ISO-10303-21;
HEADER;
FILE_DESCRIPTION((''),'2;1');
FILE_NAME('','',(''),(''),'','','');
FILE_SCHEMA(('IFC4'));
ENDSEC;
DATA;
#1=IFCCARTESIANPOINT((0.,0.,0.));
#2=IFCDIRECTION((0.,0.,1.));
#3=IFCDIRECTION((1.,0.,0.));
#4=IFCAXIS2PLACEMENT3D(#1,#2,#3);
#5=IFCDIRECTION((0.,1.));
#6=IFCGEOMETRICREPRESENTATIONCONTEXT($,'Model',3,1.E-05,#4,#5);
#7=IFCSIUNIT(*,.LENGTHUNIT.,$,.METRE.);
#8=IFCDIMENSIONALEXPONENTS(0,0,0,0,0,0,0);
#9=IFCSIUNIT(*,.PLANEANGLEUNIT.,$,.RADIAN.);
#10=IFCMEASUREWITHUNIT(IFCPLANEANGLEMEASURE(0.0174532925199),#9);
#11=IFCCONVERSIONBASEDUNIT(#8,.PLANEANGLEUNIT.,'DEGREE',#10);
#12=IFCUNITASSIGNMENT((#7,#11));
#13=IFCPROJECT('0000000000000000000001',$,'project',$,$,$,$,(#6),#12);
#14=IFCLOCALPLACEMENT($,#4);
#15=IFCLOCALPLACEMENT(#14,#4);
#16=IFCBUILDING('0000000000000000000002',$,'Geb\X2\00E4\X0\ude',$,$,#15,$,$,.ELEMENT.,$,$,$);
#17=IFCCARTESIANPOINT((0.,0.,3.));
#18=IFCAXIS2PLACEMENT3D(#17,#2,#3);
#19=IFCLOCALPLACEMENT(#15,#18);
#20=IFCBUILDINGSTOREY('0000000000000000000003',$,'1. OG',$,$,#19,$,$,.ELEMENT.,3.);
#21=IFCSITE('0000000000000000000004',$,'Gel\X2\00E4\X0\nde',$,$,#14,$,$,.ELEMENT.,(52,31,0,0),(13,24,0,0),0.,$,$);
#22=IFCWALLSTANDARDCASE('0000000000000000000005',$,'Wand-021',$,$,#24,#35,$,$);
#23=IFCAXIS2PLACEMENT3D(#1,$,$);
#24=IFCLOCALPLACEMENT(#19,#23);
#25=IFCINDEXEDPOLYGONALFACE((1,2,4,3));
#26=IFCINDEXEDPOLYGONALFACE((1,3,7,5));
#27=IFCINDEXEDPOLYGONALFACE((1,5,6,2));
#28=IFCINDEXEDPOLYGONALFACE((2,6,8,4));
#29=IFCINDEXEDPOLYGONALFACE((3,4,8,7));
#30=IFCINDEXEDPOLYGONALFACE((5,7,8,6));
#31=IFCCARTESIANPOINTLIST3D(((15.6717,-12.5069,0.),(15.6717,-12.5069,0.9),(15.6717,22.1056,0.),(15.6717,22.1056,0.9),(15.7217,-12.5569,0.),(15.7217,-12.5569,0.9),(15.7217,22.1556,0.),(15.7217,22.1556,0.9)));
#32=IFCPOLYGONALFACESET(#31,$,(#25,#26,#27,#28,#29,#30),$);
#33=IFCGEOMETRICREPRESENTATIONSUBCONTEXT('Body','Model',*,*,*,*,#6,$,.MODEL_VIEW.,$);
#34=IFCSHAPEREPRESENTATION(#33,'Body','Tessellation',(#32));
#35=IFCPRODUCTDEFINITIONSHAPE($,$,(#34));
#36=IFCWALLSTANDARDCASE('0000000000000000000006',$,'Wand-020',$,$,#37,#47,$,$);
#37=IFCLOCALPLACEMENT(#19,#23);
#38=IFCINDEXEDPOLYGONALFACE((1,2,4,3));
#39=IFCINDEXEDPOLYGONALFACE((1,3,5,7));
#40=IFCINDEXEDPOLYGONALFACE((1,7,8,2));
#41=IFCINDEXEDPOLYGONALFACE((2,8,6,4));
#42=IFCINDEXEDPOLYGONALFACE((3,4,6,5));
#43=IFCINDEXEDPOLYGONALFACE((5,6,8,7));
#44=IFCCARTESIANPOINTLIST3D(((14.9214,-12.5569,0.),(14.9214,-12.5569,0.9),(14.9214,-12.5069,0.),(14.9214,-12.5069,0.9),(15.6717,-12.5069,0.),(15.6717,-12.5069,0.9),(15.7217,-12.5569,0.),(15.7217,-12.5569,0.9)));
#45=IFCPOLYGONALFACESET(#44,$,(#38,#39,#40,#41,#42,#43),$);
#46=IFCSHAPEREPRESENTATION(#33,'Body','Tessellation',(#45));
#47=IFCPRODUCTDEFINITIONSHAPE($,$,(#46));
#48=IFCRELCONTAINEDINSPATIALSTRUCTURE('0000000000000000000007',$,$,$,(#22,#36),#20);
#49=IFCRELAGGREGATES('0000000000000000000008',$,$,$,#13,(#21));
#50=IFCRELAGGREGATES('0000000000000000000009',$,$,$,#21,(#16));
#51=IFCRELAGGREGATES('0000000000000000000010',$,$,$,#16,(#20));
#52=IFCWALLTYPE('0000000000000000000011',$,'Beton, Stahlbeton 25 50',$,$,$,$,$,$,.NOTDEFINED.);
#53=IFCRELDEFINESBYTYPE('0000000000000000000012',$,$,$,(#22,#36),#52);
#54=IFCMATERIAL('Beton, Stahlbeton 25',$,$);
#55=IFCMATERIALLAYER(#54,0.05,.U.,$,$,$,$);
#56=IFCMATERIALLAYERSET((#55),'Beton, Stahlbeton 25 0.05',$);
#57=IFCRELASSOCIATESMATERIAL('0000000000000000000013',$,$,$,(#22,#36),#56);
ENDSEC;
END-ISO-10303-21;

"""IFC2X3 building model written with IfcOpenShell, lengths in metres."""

from ifc_helpers import new_model, entity, si_unit, converted_unit, direction, frame, origin_with_axes, place, context, subcontext, project, spatial, polyline, outline, extrude, material, layer, layer_set, layer_usage, type_object, element, save


model = new_model("IFC2X3")

# Units and contexts
model_context = context("Model", 3, precision=1e-05, world=origin_with_axes(), true_north=direction((0.0, 1.0)))
body_context = subcontext(model_context, "Body", "Model", "MODEL_VIEW")
ifc_project = project(units=[si_unit("LENGTHUNIT", "METRE"), converted_unit("PLANEANGLEUNIT", "DEGREE", entity("IfcPlaneAngleMeasure", 0.0174532925199), si_unit("PLANEANGLEUNIT", "RADIAN"), dimensions=[0, 0, 0, 0, 0, 0, 0])], contexts=[model_context])

# Site, building, storey
site_placement = place(None, origin_with_axes())
site = spatial("IfcSite", under=ifc_project, at=site_placement, Name="Gelände", CompositionType="ELEMENT", RefLatitude=(52, 31, 0, 0), RefLongitude=(13, 24, 0, 0), RefElevation=0.0)
building_placement = place(site_placement, origin_with_axes())
building = spatial("IfcBuilding", under=site, at=building_placement, Name="Gebäude", CompositionType="ELEMENT")
storey_placement = place(building_placement, frame((0.0, 0.0, 3.0), z_axis=(0.0, 0.0, 1.0), x_axis=(1.0, 0.0, 0.0)))
storey = spatial("IfcBuildingStorey", under=building, at=storey_placement, Name="1. OG", CompositionType="ELEMENT", Elevation=3.0)

# Shared definitions
ifc_material_1 = material(Name="Beton, Stahlbeton 25")

# Walls
ifc_layer_1 = layer(ifc_material_1, 0.05, ventilated="UNKNOWN")
ifc_layer_set_1 = layer_set([ifc_layer_1], Name="Beton, Stahlbeton 25 0.05")
ifc_layer_usage_1 = layer_usage(ifc_layer_set_1, "AXIS2", "NEGATIVE", 0.0)
wall_type_1 = type_object("IfcWallType", Name="Beton, Stahlbeton 25 50", PredefinedType="NOTDEFINED")
wall_1_placement = place(storey_placement, frame((15.6717, -12.5069, 0.0), z_axis=(0.0, 0.0, 1.0), x_axis=(0.0, 1.0, 0.0)))
element("IfcWallStandardCase", 1, at=wall_1_placement, inside=storey, type_object=wall_type_1, material=ifc_layer_usage_1, Name="Wand-021", context=body_context, shape_type="SweptSolid", body=[
    extrude(outline(polyline([(-0.05, -0.05), (34.6625, -0.05), (34.6125, 0.0), (0.0, 0.0), (-0.05, -0.05)])), origin_with_axes(), (0.0, 0.0, 1.0), 0.9),
])
ifc_layer_usage_2 = layer_usage(ifc_layer_set_1, "AXIS2", "NEGATIVE", 0.0)
wall_2_placement = place(storey_placement, frame((14.9214, -12.5069, 0.0), z_axis=(0.0, 0.0, 1.0), x_axis=(1.0, 0.0, 0.0)))
element("IfcWallStandardCase", 2, at=wall_2_placement, inside=storey, type_object=wall_type_1, material=ifc_layer_usage_2, Name="Wand-020", context=body_context, shape_type="SweptSolid", body=[
    extrude(outline(polyline([(0.0, -0.05), (0.8003, -0.05), (0.7503, 0.0), (0.0, 0.0), (0.0, -0.05)])), origin_with_axes(), (0.0, 0.0, 1.0), 0.9),
])

save(model, "model.ifc")
